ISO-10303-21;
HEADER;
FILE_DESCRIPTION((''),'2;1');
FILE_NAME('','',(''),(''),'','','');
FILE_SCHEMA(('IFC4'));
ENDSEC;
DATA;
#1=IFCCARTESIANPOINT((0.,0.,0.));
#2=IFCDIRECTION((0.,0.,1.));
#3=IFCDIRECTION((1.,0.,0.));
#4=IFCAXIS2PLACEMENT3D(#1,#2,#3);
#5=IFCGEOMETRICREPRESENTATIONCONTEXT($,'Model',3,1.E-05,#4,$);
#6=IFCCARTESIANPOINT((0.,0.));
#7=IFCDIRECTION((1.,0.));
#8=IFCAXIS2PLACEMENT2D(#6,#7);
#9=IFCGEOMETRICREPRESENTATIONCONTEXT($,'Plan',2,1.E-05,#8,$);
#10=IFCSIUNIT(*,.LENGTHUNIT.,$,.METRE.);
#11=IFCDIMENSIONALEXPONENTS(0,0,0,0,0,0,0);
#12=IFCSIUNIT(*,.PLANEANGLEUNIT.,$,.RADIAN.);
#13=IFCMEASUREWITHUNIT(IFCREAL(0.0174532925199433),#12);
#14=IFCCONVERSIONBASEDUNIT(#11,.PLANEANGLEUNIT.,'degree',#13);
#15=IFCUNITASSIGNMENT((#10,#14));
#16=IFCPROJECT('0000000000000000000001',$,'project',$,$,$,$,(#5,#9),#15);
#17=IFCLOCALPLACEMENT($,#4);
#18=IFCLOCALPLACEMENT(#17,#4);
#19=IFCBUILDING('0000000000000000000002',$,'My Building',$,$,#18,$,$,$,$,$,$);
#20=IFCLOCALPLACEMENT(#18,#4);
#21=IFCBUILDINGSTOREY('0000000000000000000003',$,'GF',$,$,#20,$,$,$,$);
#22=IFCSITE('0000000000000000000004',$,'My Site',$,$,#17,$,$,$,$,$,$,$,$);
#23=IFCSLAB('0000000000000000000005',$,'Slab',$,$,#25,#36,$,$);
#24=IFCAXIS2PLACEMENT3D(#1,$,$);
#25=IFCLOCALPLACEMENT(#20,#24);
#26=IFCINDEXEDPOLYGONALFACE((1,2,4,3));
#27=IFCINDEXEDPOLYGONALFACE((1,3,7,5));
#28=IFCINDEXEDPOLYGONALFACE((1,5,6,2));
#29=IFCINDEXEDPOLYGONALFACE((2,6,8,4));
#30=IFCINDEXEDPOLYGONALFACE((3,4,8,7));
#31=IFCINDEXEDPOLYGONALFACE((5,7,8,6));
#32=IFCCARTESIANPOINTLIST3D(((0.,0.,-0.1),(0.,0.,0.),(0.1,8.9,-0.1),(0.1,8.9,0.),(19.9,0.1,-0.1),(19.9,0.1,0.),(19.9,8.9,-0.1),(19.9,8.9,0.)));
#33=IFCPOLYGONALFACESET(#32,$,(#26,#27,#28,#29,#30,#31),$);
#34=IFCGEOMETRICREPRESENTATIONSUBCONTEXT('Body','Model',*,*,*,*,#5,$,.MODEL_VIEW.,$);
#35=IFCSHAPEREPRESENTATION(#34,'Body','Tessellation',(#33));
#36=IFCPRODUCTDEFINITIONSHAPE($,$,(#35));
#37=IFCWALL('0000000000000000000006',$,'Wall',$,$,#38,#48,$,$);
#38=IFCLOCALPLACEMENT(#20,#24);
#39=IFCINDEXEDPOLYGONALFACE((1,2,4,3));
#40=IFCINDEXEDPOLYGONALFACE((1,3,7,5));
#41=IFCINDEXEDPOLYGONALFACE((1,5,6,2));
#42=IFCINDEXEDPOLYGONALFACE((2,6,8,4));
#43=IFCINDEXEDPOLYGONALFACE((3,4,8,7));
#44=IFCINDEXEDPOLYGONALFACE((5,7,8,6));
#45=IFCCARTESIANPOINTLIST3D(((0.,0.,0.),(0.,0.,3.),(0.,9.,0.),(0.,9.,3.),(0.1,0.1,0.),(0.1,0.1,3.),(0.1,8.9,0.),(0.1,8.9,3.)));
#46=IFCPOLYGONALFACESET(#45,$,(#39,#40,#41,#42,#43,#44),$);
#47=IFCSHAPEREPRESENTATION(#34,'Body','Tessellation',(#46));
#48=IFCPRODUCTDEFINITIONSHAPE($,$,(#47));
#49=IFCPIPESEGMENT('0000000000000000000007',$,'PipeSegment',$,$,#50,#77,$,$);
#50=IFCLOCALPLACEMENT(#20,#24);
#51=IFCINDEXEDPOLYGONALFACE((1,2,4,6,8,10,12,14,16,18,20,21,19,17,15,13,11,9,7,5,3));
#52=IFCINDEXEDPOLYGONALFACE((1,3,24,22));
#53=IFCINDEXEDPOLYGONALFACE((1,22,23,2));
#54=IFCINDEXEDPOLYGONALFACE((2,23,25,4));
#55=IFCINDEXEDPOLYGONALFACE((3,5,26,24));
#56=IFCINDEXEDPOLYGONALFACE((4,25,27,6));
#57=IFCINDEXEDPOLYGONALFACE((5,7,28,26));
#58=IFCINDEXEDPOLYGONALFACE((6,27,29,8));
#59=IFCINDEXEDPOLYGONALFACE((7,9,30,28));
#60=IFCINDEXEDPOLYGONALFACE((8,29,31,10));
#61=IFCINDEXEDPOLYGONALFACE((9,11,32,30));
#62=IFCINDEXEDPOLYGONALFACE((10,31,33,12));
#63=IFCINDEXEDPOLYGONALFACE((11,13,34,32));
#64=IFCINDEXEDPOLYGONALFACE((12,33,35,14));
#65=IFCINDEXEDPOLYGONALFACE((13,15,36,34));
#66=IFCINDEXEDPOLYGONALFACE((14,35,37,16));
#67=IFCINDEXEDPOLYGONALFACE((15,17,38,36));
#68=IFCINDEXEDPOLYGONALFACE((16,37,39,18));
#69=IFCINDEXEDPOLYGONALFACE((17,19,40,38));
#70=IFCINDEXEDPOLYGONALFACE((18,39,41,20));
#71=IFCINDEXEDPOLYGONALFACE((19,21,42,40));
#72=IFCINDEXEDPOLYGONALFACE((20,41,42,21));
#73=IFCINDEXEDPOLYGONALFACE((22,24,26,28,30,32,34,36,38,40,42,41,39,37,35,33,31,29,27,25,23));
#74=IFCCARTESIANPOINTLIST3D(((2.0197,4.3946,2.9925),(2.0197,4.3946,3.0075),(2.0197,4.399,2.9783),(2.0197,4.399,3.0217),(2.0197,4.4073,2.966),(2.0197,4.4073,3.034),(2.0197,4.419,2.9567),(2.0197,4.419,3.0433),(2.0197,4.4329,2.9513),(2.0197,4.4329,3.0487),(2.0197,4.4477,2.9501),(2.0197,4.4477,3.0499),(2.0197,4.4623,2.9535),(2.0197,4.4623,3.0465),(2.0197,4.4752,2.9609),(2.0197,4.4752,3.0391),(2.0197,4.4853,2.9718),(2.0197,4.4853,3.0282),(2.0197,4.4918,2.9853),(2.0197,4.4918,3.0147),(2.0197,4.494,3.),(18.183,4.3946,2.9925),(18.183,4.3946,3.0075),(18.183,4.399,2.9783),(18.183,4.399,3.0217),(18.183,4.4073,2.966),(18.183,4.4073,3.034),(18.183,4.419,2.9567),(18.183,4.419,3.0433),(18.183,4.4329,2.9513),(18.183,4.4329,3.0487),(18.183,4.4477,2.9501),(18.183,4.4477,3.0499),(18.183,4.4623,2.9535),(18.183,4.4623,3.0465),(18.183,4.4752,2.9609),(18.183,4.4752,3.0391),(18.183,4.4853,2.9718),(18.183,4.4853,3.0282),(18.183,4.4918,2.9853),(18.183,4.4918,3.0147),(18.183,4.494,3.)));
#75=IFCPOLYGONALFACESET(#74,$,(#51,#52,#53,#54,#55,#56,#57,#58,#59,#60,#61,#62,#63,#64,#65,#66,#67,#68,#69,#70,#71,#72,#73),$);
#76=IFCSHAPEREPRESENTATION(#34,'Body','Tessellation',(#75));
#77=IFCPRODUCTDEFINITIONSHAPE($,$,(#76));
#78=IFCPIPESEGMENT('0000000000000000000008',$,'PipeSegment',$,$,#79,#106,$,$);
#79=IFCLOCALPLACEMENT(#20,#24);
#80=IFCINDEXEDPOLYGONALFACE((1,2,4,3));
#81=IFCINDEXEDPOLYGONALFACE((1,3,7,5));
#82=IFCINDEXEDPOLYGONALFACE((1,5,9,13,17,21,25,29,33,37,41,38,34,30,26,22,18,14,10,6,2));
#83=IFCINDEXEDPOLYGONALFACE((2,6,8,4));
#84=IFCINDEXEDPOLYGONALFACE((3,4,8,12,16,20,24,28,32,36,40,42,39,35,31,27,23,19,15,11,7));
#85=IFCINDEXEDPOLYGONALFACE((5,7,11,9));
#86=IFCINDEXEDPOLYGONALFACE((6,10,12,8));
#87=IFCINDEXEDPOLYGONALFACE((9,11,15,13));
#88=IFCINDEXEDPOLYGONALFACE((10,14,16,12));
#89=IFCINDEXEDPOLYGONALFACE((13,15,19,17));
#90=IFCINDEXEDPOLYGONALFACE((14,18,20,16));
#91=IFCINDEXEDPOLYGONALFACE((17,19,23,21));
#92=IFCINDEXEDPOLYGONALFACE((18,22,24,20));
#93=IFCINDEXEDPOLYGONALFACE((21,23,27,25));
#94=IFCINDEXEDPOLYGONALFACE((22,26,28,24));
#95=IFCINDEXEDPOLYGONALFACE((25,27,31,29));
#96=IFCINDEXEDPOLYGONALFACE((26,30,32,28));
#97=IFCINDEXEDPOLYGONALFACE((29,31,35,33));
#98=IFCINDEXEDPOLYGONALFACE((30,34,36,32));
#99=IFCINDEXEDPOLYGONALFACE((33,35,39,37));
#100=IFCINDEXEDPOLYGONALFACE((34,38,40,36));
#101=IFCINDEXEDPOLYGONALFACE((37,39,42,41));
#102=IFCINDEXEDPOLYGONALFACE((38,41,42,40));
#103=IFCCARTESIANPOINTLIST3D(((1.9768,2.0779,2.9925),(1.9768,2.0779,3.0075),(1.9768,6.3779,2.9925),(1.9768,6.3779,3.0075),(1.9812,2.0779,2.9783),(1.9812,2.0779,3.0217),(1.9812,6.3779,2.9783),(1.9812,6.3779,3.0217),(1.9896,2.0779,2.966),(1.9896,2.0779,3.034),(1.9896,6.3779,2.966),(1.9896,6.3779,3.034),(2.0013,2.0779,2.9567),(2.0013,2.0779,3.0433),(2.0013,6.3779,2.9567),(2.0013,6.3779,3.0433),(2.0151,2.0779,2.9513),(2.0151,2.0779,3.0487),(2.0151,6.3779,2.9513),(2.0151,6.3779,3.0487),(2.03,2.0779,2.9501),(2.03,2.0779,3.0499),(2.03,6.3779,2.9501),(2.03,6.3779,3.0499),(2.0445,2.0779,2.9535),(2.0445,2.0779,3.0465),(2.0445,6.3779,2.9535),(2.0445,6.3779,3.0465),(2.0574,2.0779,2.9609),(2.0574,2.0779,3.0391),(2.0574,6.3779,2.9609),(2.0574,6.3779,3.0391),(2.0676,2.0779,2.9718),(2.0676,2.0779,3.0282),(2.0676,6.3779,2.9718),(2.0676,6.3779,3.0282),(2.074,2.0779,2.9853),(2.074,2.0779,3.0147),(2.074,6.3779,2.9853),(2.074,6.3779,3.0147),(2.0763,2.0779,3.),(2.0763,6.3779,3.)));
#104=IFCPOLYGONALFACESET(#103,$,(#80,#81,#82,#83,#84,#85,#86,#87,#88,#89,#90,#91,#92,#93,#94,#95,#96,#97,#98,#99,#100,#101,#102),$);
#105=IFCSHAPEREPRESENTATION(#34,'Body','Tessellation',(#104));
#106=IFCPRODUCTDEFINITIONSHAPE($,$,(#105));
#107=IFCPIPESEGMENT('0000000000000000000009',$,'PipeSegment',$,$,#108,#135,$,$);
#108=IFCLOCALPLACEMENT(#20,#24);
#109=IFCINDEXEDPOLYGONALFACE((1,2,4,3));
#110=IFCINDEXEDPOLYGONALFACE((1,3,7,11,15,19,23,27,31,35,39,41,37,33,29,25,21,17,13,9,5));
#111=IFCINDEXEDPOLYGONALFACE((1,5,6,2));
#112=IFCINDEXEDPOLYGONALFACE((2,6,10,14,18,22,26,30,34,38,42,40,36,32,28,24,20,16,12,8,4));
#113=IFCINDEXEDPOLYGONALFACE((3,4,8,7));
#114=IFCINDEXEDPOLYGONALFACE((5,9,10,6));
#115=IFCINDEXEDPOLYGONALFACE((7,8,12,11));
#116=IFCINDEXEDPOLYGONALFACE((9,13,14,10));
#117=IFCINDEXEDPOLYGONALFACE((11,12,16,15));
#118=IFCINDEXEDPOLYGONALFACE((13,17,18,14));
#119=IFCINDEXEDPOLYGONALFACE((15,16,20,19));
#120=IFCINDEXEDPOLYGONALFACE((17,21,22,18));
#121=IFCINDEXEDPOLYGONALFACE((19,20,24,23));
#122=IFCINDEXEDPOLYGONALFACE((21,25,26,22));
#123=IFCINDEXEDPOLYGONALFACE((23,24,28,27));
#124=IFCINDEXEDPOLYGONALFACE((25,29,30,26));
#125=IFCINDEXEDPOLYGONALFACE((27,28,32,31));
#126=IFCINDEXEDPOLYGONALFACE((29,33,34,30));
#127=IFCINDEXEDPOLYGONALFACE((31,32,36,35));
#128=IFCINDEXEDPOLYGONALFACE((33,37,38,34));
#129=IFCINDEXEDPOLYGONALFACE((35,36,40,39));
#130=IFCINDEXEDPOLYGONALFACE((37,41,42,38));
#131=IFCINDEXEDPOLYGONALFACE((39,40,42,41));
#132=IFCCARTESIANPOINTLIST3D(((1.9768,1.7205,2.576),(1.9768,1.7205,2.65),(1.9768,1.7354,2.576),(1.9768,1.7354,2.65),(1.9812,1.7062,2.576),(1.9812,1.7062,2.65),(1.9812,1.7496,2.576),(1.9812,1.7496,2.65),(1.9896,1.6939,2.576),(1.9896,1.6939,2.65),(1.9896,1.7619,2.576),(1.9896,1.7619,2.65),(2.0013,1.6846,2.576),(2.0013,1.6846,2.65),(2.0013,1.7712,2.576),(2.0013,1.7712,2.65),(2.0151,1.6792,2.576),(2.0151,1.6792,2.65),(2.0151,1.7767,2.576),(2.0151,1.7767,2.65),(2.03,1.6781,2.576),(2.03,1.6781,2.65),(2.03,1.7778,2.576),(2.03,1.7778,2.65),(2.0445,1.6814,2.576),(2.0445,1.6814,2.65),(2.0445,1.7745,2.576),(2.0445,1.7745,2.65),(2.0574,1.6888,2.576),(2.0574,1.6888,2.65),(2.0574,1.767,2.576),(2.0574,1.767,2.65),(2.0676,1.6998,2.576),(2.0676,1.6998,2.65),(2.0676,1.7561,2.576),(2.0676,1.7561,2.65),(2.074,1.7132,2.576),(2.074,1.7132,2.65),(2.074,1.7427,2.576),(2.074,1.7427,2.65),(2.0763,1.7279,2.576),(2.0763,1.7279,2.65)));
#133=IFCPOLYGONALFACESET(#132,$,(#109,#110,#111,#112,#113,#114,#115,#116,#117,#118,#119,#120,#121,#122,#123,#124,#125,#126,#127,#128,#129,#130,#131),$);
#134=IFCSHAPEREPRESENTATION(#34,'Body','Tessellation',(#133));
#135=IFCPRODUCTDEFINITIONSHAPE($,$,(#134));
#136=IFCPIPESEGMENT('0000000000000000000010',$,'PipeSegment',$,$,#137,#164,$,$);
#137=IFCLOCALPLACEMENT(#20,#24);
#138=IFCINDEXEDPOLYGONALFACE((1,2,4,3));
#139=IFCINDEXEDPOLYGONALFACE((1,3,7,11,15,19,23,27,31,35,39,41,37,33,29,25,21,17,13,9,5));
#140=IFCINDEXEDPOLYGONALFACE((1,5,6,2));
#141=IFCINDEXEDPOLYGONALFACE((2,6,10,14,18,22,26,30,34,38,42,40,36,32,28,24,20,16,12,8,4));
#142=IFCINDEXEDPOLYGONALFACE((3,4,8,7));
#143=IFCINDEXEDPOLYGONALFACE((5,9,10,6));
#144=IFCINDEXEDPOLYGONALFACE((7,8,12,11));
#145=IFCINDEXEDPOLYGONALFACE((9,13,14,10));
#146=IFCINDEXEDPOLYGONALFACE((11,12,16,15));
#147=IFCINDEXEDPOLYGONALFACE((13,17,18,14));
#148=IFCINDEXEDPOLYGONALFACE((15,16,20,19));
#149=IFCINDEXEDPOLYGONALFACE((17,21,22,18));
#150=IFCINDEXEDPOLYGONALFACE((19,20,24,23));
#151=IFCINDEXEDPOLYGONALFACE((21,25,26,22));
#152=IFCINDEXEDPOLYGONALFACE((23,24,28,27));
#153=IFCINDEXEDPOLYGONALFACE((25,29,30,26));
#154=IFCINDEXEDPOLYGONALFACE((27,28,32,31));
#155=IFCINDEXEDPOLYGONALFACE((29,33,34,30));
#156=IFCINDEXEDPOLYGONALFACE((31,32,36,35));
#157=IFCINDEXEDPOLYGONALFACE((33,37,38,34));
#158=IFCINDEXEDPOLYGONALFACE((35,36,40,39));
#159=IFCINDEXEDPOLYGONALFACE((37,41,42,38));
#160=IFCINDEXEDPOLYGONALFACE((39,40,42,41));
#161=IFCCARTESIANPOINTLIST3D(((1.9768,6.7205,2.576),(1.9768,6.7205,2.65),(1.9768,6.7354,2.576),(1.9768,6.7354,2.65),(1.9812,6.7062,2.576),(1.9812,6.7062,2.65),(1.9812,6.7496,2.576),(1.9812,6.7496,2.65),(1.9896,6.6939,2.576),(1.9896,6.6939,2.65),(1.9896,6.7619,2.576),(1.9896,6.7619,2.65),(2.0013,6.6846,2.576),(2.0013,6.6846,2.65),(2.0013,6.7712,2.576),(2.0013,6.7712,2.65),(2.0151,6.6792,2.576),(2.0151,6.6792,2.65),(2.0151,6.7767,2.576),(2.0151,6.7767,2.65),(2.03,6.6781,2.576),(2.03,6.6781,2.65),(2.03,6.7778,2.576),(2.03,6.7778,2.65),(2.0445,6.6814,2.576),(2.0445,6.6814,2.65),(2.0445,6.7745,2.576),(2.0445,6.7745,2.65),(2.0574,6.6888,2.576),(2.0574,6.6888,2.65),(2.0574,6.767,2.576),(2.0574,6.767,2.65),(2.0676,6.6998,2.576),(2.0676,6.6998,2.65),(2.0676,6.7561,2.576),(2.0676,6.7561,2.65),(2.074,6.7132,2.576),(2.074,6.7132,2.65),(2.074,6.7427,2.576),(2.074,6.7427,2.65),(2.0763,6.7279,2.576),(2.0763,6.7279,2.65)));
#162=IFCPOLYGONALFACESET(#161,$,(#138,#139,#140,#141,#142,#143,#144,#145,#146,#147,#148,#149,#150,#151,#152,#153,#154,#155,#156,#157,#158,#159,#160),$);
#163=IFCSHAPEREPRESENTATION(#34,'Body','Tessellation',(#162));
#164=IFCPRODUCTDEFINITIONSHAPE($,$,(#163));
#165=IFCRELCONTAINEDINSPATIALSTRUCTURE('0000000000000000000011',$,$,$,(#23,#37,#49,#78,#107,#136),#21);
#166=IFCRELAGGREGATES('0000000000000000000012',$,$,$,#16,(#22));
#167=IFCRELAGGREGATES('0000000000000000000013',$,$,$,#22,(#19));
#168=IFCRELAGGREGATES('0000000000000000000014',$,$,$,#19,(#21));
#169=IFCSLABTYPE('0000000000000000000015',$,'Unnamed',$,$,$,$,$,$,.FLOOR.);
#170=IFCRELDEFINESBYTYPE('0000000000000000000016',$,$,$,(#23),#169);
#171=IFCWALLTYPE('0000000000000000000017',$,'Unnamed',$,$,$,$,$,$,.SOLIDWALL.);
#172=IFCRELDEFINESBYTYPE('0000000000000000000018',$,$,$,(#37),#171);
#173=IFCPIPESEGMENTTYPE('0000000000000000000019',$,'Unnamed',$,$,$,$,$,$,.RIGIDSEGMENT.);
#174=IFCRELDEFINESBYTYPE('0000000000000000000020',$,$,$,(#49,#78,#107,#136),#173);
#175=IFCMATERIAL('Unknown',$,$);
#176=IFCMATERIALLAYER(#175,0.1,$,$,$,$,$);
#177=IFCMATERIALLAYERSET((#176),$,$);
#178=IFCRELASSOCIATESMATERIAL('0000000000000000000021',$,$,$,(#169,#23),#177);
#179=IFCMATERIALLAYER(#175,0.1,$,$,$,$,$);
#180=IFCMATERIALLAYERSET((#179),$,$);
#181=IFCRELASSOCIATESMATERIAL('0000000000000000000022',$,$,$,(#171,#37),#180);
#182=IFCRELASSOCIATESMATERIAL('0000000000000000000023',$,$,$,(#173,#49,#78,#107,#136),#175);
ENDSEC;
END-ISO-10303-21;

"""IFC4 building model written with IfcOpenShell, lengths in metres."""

from ifc_helpers import new_model, entity, si_unit, converted_unit, frame, origin_with_axes, origin_2d_with_axis, place, context, subcontext, project, spatial, line, indexed_curve, circle, outline, extrude, material, layer, layer_set, layer_usage, material_profile, profile_set, profile_usage, type_object, element, save


model = new_model("IFC4")

# Units and contexts
model_context = context("Model", 3, precision=1e-05, world=origin_with_axes())
plan_context = context("Plan", 2, precision=1e-05, world=origin_2d_with_axis())
body_context_1 = subcontext(model_context, "Body", "Model", "MODEL_VIEW")
ifc_project = project(units=[si_unit("LENGTHUNIT", "METRE"), converted_unit("PLANEANGLEUNIT", "degree", entity("IfcReal", 0.0174532925199433), si_unit("PLANEANGLEUNIT", "RADIAN"), dimensions=[0, 0, 0, 0, 0, 0, 0])], contexts=[model_context, plan_context])

# Site, building, storey
site_placement = place(None, origin_with_axes())
site = spatial("IfcSite", under=ifc_project, at=site_placement, Name="My Site")
building_placement = place(site_placement, origin_with_axes())
building = spatial("IfcBuilding", under=site, at=building_placement, Name="My Building")
storey_placement = place(building_placement, origin_with_axes())
storey = spatial("IfcBuildingStorey", under=building, at=storey_placement, Name="GF")

# Slab
ifc_material = material(Name="Unknown")
ifc_layer_1 = layer(ifc_material, 0.1)
ifc_layer_set_1 = layer_set([ifc_layer_1])
ifc_layer_usage_1 = layer_usage(ifc_layer_set_1, "AXIS3", "POSITIVE", -0.1)
slab_type = type_object("IfcSlabType", Name="Unnamed", PredefinedType="FLOOR", material=ifc_layer_set_1)
slab_placement = place(storey_placement, frame((0.1, 8.9, 0.0), z_axis=(0.0, 0.0, 1.0), x_axis=(1.0, 0.0, 0.0)))
element("IfcSlab", 1, at=slab_placement, inside=storey, type_object=slab_type, material=ifc_layer_usage_1, Name="Slab", context=body_context_1, shape_type="SweptSolid", body=[
    extrude(outline(indexed_curve([(0.0, 0.0), (19.8, 0.0), (19.8, -8.8), (-0.1, -8.9), (0.0, 0.0)])), frame((0.0, 0.0, -0.1), z_axis=(0.0, 0.0, 1.0), x_axis=(1.0, 0.0, 0.0)), (0.0, 0.0, 1.0), 0.1),
])

# Shared definitions
ifc_layer_2 = layer(ifc_material, 0.1)
ifc_layer_set_2 = layer_set([ifc_layer_2])
wall_type = type_object("IfcWallType", Name="Unnamed", PredefinedType="SOLIDWALL", material=ifc_layer_set_2)

# Wall
ifc_layer_usage_2 = layer_usage(ifc_layer_set_2, "AXIS2", "POSITIVE", 0.0)
wall_1_placement = place(storey_placement, frame((0.0, 9.0, 0.0), z_axis=(0.0, 0.0, 1.0), x_axis=(0.0, -1.0, 0.0)))
element("IfcWall", 2, at=wall_1_placement, inside=storey, type_object=wall_type, material=ifc_layer_usage_2, Name="Wall", context=body_context_1, shape_type="SweptSolid", body=[
    extrude(outline(indexed_curve([(0.0, 0.0), (0.1, 0.1), (8.9, 0.1), (9.0, 0.0)], segments=[line(1, 2, 3, 4, 1)])), origin_with_axes(), (0.0, 0.0, 1.0), 3.0),
])

# Pipe segments
ifc_material_profile = material_profile(ifc_material, circle(Radius=0.05))
ifc_profile_set = profile_set([ifc_material_profile])
ifc_profile_usage_1 = profile_usage(ifc_profile_set, cardinal=5)
pipe_segment_type = type_object("IfcPipeSegmentType", Name="Unnamed", PredefinedType="RIGIDSEGMENT", material=ifc_profile_set)
pipe_segment_1_placement = place(storey_placement, frame((2.0197, 4.444, 3.0), z_axis=(1.0, 0.0, 0.0), x_axis=(0.0, 1.0, 0.0)))
element("IfcPipeSegment", 3, at=pipe_segment_1_placement, inside=storey, type_object=pipe_segment_type, material=ifc_profile_usage_1, Name="PipeSegment", context=body_context_1, shape_type="SweptSolid", body=[
    extrude(circle(Radius=0.05), origin_with_axes(), (0.0, 0.0, 1.0), 16.1634),
])
ifc_profile_usage_2 = profile_usage(ifc_profile_set, cardinal=5)
pipe_segment_2_placement = place(storey_placement, frame((2.0263, 6.3779, 3.0), z_axis=(0.0, -1.0, 0.0), x_axis=(1.0, 0.0, 0.0)))
element("IfcPipeSegment", 4, at=pipe_segment_2_placement, inside=storey, type_object=pipe_segment_type, material=ifc_profile_usage_2, Name="PipeSegment", context=body_context_1, shape_type="SweptSolid", body=[
    extrude(circle(Radius=0.05), origin_with_axes(), (0.0, 0.0, 1.0), 4.3),
])
ifc_profile_usage_3 = profile_usage(ifc_profile_set, cardinal=5)
pipe_segment_3_placement = place(storey_placement, frame((2.0263, 1.7279, 2.576), z_axis=(0.0, 0.0, 1.0), x_axis=(1.0, 0.0, 0.0)))
element("IfcPipeSegment", 5, at=pipe_segment_3_placement, inside=storey, type_object=pipe_segment_type, material=ifc_profile_usage_3, Name="PipeSegment", context=body_context_1, shape_type="SweptSolid", body=[
    extrude(circle(Radius=0.05), origin_with_axes(), (0.0, 0.0, 1.0), 0.074),
])
ifc_profile_usage_4 = profile_usage(ifc_profile_set, cardinal=5)
pipe_segment_4_placement = place(storey_placement, frame((2.0263, 6.7279, 2.576), z_axis=(0.0, 0.0, 1.0), x_axis=(1.0, 0.0, 0.0)))
element("IfcPipeSegment", 6, at=pipe_segment_4_placement, inside=storey, type_object=pipe_segment_type, material=ifc_profile_usage_4, Name="PipeSegment", context=body_context_1, shape_type="SweptSolid", body=[
    extrude(circle(Radius=0.05), origin_with_axes(), (0.0, 0.0, 1.0), 0.074),
])

save(model, "model.ifc")
